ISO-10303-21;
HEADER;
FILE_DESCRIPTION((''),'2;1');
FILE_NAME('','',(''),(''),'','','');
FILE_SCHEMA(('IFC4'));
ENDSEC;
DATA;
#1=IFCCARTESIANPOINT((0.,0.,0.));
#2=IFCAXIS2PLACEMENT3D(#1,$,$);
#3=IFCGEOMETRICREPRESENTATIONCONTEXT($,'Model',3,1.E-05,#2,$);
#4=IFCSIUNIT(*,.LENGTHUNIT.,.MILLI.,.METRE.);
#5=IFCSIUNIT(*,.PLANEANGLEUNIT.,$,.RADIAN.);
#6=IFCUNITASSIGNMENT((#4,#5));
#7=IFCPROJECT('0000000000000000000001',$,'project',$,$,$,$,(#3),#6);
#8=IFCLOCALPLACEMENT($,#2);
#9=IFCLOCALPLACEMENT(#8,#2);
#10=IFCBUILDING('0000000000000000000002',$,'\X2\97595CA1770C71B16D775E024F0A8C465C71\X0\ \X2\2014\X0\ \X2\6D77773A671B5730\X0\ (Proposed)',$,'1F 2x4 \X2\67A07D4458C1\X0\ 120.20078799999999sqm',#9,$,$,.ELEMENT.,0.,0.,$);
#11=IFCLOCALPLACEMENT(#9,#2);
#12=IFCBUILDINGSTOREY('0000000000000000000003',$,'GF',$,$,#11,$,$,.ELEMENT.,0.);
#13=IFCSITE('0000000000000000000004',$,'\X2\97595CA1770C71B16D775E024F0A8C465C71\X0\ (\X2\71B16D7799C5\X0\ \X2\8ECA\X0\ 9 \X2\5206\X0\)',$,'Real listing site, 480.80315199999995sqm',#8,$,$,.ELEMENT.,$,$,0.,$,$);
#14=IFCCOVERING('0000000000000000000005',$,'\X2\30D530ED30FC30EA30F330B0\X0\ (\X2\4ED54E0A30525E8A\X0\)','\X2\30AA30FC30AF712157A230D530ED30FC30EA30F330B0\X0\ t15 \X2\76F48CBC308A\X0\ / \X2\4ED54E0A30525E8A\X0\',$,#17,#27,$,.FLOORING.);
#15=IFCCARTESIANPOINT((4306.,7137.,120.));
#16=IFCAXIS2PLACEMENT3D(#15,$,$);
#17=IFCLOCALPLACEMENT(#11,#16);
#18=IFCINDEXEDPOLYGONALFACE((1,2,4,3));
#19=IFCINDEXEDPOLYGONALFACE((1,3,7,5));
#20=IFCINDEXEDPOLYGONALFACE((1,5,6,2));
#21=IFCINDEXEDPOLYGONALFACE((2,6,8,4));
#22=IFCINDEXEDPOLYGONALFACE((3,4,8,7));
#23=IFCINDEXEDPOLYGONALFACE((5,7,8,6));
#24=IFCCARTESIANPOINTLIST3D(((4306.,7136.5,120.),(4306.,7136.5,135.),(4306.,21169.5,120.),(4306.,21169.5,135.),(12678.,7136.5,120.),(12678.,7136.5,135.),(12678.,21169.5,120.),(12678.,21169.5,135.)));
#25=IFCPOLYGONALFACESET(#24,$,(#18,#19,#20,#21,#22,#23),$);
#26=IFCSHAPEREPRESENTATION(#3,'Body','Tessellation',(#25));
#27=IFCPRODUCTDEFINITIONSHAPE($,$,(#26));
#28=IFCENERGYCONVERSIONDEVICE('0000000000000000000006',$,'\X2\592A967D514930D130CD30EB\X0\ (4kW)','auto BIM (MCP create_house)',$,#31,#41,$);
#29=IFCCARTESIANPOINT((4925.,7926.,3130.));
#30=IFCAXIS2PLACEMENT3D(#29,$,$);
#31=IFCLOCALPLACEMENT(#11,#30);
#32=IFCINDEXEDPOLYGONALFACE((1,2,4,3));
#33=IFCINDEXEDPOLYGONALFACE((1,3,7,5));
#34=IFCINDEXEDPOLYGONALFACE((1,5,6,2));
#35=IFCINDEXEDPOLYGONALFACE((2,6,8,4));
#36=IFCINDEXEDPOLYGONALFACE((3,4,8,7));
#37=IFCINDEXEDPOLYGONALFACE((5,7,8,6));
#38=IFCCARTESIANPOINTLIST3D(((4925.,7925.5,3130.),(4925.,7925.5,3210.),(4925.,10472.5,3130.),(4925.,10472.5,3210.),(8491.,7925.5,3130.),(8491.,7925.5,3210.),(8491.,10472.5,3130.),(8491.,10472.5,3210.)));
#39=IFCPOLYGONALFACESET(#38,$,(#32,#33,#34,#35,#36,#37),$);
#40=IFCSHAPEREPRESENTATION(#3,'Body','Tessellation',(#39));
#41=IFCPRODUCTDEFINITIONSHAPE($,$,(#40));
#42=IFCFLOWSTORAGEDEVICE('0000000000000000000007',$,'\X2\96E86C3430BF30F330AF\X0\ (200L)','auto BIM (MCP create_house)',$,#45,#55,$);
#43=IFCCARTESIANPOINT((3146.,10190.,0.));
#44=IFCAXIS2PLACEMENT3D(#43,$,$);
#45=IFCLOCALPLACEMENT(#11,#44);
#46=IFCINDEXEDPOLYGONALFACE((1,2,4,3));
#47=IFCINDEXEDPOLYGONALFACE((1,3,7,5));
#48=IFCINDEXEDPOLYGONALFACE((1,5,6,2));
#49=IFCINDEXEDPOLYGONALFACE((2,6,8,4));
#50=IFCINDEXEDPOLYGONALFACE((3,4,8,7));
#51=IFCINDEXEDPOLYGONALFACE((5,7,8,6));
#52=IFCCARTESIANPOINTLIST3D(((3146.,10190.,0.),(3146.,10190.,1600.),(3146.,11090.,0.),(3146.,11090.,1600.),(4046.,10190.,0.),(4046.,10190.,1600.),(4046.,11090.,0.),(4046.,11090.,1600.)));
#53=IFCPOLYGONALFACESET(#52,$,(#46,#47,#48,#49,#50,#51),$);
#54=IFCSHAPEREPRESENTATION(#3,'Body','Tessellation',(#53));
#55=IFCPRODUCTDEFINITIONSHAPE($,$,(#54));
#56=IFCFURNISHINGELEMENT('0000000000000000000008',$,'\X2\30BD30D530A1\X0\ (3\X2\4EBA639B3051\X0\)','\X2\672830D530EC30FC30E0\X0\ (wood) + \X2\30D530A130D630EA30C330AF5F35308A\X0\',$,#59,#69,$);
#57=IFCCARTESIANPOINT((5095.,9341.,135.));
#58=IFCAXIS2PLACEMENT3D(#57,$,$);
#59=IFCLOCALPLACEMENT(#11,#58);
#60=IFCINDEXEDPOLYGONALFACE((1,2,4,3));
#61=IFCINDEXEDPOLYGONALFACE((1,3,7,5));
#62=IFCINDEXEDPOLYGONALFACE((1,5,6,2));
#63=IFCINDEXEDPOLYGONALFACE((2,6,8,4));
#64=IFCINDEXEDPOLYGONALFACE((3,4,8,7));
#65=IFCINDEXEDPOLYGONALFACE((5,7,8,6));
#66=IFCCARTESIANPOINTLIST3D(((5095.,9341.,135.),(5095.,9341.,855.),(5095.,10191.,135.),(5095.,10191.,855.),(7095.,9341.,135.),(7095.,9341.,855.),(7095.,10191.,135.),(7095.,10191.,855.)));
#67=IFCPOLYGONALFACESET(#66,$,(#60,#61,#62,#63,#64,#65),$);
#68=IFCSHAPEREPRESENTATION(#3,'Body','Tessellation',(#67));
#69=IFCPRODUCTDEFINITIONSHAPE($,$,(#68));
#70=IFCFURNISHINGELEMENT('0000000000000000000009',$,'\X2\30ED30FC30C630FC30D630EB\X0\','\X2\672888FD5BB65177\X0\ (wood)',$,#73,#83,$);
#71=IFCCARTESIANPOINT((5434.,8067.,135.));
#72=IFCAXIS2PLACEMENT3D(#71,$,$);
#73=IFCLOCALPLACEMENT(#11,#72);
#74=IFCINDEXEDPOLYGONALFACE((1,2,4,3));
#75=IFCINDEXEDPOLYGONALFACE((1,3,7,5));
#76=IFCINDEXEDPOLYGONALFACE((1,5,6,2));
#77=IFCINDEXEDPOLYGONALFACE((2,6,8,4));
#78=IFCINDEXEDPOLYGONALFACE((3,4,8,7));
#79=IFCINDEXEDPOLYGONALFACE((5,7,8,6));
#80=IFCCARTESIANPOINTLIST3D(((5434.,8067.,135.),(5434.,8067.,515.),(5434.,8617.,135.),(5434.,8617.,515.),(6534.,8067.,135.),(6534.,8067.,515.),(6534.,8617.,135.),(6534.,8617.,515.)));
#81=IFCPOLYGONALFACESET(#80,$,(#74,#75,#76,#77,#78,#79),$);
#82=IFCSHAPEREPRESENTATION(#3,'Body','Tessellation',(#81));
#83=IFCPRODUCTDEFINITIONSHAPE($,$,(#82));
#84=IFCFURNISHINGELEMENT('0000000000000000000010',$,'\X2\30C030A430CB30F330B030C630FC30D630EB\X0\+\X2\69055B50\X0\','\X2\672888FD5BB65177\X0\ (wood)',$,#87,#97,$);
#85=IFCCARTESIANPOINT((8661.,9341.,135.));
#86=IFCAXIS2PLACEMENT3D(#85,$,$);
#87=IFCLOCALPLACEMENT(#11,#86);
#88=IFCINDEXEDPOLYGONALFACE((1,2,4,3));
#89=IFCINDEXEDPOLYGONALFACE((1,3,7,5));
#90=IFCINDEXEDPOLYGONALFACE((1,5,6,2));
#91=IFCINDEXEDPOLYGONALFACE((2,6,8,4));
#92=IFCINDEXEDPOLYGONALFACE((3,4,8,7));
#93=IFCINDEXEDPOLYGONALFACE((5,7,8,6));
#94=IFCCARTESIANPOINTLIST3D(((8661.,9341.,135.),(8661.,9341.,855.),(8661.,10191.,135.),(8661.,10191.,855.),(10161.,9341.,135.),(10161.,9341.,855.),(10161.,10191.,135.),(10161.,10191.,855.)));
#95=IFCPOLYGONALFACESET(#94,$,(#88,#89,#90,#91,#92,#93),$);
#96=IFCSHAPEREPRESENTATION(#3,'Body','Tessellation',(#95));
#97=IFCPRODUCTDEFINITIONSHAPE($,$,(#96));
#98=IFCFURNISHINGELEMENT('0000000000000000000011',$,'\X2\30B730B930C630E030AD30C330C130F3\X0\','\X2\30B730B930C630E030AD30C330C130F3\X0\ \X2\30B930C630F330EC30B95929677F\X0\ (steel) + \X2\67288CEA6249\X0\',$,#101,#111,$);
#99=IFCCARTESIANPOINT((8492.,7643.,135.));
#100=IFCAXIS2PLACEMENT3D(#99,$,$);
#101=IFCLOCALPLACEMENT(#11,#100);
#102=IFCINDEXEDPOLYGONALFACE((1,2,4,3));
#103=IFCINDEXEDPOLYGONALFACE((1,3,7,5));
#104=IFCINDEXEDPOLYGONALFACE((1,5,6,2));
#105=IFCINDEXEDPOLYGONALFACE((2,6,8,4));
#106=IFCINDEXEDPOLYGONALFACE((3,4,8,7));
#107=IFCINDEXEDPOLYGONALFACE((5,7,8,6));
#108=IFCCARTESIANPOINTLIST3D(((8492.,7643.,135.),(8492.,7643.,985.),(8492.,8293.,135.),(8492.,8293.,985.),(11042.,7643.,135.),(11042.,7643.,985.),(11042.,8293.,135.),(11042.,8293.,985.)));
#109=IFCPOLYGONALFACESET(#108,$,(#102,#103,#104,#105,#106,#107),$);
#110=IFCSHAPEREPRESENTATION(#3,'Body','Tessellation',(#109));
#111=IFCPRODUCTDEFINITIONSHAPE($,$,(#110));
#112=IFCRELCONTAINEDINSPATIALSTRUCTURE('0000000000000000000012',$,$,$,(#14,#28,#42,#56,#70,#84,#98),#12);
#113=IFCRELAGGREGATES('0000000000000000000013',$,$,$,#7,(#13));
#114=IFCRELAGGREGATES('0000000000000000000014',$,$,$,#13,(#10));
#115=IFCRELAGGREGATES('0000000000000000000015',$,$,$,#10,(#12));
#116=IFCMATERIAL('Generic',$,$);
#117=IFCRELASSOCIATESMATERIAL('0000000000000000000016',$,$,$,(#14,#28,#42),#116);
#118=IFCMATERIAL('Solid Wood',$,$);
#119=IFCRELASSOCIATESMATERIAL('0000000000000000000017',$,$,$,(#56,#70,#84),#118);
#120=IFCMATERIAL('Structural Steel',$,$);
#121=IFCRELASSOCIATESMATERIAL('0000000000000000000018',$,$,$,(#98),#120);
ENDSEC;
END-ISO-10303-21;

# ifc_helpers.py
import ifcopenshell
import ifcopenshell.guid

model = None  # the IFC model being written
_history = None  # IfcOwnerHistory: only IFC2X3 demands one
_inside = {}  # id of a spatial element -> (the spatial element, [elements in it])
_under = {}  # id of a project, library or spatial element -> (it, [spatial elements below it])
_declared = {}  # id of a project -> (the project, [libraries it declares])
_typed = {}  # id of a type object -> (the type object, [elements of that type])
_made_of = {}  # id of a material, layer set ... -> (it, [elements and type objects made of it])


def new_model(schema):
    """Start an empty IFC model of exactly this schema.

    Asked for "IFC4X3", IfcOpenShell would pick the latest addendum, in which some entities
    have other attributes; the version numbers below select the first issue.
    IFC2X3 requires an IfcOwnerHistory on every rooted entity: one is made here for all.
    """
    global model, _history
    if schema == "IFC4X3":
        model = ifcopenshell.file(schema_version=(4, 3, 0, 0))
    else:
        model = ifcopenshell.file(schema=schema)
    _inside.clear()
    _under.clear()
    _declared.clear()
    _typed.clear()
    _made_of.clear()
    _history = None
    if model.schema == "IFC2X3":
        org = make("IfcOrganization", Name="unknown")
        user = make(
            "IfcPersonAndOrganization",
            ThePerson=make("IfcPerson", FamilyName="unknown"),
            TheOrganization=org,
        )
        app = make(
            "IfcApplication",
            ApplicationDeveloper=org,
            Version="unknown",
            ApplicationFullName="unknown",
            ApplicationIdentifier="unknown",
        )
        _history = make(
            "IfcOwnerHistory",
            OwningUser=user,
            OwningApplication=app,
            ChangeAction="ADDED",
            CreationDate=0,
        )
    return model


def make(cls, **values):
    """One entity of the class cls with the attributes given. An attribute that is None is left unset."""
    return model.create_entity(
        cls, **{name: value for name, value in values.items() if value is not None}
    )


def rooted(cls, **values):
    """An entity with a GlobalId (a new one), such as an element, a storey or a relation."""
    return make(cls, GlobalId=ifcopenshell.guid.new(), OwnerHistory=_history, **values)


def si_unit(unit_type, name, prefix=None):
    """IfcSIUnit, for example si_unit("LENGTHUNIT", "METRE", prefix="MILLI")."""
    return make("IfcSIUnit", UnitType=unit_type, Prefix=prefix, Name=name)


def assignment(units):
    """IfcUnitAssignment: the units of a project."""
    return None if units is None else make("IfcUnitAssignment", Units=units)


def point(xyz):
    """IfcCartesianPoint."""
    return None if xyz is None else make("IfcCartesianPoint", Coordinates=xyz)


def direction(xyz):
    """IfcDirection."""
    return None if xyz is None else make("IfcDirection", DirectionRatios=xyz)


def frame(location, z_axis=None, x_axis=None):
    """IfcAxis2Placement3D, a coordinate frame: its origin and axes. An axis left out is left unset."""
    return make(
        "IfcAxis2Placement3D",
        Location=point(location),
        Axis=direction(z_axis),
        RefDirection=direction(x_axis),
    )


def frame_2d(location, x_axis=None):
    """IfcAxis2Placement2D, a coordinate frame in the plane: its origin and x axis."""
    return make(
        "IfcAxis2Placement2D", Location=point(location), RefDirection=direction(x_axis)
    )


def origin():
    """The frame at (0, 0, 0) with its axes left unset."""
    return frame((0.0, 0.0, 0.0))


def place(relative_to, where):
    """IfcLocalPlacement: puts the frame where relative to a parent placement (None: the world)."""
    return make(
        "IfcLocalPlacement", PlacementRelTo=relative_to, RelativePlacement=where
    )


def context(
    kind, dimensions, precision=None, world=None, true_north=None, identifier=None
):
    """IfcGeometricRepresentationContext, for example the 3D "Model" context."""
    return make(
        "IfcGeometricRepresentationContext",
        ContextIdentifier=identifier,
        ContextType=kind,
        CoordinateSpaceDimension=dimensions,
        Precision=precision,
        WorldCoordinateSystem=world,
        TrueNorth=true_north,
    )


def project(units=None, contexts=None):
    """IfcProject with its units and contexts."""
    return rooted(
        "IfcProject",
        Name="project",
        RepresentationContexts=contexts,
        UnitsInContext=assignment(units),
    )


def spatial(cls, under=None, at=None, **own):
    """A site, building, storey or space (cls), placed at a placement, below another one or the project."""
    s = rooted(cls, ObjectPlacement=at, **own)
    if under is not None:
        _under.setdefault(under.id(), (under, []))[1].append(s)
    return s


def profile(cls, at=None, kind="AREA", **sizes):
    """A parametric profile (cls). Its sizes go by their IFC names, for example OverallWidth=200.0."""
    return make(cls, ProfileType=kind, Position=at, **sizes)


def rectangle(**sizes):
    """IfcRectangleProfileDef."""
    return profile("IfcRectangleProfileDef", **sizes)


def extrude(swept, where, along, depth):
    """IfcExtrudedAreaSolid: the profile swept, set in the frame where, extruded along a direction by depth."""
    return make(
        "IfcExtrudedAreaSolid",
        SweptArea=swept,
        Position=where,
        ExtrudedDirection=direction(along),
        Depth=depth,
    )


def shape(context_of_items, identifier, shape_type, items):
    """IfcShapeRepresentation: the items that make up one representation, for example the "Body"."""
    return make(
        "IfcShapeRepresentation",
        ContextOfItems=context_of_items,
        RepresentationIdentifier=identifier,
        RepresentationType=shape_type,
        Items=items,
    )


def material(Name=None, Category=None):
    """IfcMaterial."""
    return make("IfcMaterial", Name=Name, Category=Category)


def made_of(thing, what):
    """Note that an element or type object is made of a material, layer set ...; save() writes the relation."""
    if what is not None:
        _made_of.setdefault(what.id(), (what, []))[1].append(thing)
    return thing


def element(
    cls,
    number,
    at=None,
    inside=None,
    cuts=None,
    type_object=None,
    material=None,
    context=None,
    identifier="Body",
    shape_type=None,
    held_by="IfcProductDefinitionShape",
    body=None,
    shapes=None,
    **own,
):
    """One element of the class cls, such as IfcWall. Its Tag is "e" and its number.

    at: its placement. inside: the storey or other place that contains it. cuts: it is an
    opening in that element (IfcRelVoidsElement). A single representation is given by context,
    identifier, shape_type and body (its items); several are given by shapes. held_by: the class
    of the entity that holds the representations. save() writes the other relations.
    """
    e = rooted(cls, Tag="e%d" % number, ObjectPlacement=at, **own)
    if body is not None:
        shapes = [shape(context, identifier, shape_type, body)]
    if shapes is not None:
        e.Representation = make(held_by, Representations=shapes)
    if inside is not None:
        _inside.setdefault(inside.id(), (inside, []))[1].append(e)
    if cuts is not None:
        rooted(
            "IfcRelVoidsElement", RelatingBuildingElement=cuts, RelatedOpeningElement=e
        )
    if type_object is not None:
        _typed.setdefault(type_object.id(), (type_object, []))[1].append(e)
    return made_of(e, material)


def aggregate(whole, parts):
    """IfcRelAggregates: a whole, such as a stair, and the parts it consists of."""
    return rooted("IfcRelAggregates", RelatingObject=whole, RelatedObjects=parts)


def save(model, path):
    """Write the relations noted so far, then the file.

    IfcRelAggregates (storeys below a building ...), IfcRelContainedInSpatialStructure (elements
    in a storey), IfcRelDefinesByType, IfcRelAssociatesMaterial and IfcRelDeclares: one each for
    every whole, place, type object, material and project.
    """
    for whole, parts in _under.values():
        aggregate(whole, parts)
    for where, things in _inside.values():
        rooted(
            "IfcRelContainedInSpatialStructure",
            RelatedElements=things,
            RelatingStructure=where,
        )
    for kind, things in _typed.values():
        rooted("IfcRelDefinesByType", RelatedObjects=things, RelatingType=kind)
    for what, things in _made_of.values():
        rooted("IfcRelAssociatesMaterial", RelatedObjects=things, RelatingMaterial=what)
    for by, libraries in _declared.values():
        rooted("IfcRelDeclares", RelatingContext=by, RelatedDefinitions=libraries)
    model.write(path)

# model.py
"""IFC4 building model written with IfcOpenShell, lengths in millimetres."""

from ifc_helpers import new_model, si_unit, frame, frame_2d, origin, place, context, project, spatial, rectangle, extrude, material, element, save


model = new_model("IFC4")

# Units and contexts
model_context = context("Model", 3, precision=1e-05, world=origin())
ifc_project = project(units=[si_unit("LENGTHUNIT", "METRE", prefix="MILLI"), si_unit("PLANEANGLEUNIT", "RADIAN")], contexts=[model_context])

# Site, building, storey
site_placement = place(None, origin())
site = spatial("IfcSite", under=ifc_project, at=site_placement, Name="静岡県熱海市伊豆山 (熱海駅 車 9 分)", ObjectType="Real listing site, 480.80315199999995sqm", CompositionType="ELEMENT", RefElevation=0.0)
building_placement = place(site_placement, origin())
building = spatial("IfcBuilding", under=site, at=building_placement, Name="静岡県熱海市伊豆山 — 海眺望地 (Proposed)", ObjectType="1F 2x4 枠組壁 120.20078799999999sqm", CompositionType="ELEMENT", ElevationOfRefHeight=0.0, ElevationOfTerrain=0.0)
storey_placement = place(building_placement, origin())
storey = spatial("IfcBuildingStorey", under=building, at=storey_placement, Name="GF", CompositionType="ELEMENT", Elevation=0.0)

# Shared definitions
ifc_material_1 = material(Name="Solid Wood")

# Shared definitions
ifc_material_2 = material(Name="Structural Steel")

# Covering
ifc_material_3 = material(Name="Generic")
covering_placement = place(storey_placement, frame((4306.0, 7137.0, 120.0)))
element("IfcCovering", 1, at=covering_placement, inside=storey, material=ifc_material_3, Name="フローリング (仕上げ床)", Description="オーク無垢フローリング t15 直貼り / 仕上げ床", PredefinedType="FLOORING", context=model_context, shape_type="SweptSolid", body=[
    extrude(rectangle(XDim=8372.0, YDim=14033.0, at=frame_2d((4186.0, 7016.0))), frame((4306.0, 7137.0, 120.0)), (0.0, 0.0, 1.0), 15.0),
])

# Energy conversion device
energy_conversion_device_placement = place(storey_placement, frame((4925.0, 7926.0, 3130.0)))
element("IfcEnergyConversionDevice", 2, at=energy_conversion_device_placement, inside=storey, material=ifc_material_3, Name="太陽光パネル (4kW)", Description="auto BIM (MCP create_house)", context=model_context, shape_type="SweptSolid", body=[
    extrude(rectangle(XDim=3566.0, YDim=2547.0, at=frame_2d((1783.0, 1273.0))), frame((4925.0, 7926.0, 3130.0)), (0.0, 0.0, 1.0), 80.0),
])

# Flow storage device
flow_storage_device_placement = place(storey_placement, frame((3146.0, 10190.0, 0.0)))
element("IfcFlowStorageDevice", 3, at=flow_storage_device_placement, inside=storey, material=ifc_material_3, Name="雨水タンク (200L)", Description="auto BIM (MCP create_house)", context=model_context, shape_type="SweptSolid", body=[
    extrude(rectangle(XDim=900.0, YDim=900.0, at=frame_2d((450.0, 450.0))), frame((3146.0, 10190.0, 0.0)), (0.0, 0.0, 1.0), 1600.0),
])

# Furnishing elements
furnishing_1_placement = place(storey_placement, frame((5095.0, 9341.0, 135.0)))
element("IfcFurnishingElement", 4, at=furnishing_1_placement, inside=storey, material=ifc_material_1, Name="ソファ (3人掛け)", Description="木フレーム (wood) + ファブリック張り", context=model_context, shape_type="SweptSolid", body=[
    extrude(rectangle(XDim=2000.0, YDim=850.0, at=frame_2d((1000.0, 425.0))), frame((5095.0, 9341.0, 135.0)), (0.0, 0.0, 1.0), 720.0),
])
furnishing_2_placement = place(storey_placement, frame((5434.0, 8067.0, 135.0)))
element("IfcFurnishingElement", 5, at=furnishing_2_placement, inside=storey, material=ifc_material_1, Name="ローテーブル", Description="木製家具 (wood)", context=model_context, shape_type="SweptSolid", body=[
    extrude(rectangle(XDim=1100.0, YDim=550.0, at=frame_2d((550.0, 275.0))), frame((5434.0, 8067.0, 135.0)), (0.0, 0.0, 1.0), 380.0),
])
furnishing_3_placement = place(storey_placement, frame((8661.0, 9341.0, 135.0)))
element("IfcFurnishingElement", 6, at=furnishing_3_placement, inside=storey, material=ifc_material_1, Name="ダイニングテーブル+椅子", Description="木製家具 (wood)", context=model_context, shape_type="SweptSolid", body=[
    extrude(rectangle(XDim=1500.0, YDim=850.0, at=frame_2d((750.0, 425.0))), frame((8661.0, 9341.0, 135.0)), (0.0, 0.0, 1.0), 720.0),
])
furnishing_4_placement = place(storey_placement, frame((8492.0, 7643.0, 135.0)))
element("IfcFurnishingElement", 7, at=furnishing_4_placement, inside=storey, material=ifc_material_2, Name="システムキッチン", Description="システムキッチン ステンレス天板 (steel) + 木質扉", context=model_context, shape_type="SweptSolid", body=[
    extrude(rectangle(XDim=2550.0, YDim=650.0, at=frame_2d((1275.0, 325.0))), frame((8492.0, 7643.0, 135.0)), (0.0, 0.0, 1.0), 850.0),
])

save(model, "model.ifc")
